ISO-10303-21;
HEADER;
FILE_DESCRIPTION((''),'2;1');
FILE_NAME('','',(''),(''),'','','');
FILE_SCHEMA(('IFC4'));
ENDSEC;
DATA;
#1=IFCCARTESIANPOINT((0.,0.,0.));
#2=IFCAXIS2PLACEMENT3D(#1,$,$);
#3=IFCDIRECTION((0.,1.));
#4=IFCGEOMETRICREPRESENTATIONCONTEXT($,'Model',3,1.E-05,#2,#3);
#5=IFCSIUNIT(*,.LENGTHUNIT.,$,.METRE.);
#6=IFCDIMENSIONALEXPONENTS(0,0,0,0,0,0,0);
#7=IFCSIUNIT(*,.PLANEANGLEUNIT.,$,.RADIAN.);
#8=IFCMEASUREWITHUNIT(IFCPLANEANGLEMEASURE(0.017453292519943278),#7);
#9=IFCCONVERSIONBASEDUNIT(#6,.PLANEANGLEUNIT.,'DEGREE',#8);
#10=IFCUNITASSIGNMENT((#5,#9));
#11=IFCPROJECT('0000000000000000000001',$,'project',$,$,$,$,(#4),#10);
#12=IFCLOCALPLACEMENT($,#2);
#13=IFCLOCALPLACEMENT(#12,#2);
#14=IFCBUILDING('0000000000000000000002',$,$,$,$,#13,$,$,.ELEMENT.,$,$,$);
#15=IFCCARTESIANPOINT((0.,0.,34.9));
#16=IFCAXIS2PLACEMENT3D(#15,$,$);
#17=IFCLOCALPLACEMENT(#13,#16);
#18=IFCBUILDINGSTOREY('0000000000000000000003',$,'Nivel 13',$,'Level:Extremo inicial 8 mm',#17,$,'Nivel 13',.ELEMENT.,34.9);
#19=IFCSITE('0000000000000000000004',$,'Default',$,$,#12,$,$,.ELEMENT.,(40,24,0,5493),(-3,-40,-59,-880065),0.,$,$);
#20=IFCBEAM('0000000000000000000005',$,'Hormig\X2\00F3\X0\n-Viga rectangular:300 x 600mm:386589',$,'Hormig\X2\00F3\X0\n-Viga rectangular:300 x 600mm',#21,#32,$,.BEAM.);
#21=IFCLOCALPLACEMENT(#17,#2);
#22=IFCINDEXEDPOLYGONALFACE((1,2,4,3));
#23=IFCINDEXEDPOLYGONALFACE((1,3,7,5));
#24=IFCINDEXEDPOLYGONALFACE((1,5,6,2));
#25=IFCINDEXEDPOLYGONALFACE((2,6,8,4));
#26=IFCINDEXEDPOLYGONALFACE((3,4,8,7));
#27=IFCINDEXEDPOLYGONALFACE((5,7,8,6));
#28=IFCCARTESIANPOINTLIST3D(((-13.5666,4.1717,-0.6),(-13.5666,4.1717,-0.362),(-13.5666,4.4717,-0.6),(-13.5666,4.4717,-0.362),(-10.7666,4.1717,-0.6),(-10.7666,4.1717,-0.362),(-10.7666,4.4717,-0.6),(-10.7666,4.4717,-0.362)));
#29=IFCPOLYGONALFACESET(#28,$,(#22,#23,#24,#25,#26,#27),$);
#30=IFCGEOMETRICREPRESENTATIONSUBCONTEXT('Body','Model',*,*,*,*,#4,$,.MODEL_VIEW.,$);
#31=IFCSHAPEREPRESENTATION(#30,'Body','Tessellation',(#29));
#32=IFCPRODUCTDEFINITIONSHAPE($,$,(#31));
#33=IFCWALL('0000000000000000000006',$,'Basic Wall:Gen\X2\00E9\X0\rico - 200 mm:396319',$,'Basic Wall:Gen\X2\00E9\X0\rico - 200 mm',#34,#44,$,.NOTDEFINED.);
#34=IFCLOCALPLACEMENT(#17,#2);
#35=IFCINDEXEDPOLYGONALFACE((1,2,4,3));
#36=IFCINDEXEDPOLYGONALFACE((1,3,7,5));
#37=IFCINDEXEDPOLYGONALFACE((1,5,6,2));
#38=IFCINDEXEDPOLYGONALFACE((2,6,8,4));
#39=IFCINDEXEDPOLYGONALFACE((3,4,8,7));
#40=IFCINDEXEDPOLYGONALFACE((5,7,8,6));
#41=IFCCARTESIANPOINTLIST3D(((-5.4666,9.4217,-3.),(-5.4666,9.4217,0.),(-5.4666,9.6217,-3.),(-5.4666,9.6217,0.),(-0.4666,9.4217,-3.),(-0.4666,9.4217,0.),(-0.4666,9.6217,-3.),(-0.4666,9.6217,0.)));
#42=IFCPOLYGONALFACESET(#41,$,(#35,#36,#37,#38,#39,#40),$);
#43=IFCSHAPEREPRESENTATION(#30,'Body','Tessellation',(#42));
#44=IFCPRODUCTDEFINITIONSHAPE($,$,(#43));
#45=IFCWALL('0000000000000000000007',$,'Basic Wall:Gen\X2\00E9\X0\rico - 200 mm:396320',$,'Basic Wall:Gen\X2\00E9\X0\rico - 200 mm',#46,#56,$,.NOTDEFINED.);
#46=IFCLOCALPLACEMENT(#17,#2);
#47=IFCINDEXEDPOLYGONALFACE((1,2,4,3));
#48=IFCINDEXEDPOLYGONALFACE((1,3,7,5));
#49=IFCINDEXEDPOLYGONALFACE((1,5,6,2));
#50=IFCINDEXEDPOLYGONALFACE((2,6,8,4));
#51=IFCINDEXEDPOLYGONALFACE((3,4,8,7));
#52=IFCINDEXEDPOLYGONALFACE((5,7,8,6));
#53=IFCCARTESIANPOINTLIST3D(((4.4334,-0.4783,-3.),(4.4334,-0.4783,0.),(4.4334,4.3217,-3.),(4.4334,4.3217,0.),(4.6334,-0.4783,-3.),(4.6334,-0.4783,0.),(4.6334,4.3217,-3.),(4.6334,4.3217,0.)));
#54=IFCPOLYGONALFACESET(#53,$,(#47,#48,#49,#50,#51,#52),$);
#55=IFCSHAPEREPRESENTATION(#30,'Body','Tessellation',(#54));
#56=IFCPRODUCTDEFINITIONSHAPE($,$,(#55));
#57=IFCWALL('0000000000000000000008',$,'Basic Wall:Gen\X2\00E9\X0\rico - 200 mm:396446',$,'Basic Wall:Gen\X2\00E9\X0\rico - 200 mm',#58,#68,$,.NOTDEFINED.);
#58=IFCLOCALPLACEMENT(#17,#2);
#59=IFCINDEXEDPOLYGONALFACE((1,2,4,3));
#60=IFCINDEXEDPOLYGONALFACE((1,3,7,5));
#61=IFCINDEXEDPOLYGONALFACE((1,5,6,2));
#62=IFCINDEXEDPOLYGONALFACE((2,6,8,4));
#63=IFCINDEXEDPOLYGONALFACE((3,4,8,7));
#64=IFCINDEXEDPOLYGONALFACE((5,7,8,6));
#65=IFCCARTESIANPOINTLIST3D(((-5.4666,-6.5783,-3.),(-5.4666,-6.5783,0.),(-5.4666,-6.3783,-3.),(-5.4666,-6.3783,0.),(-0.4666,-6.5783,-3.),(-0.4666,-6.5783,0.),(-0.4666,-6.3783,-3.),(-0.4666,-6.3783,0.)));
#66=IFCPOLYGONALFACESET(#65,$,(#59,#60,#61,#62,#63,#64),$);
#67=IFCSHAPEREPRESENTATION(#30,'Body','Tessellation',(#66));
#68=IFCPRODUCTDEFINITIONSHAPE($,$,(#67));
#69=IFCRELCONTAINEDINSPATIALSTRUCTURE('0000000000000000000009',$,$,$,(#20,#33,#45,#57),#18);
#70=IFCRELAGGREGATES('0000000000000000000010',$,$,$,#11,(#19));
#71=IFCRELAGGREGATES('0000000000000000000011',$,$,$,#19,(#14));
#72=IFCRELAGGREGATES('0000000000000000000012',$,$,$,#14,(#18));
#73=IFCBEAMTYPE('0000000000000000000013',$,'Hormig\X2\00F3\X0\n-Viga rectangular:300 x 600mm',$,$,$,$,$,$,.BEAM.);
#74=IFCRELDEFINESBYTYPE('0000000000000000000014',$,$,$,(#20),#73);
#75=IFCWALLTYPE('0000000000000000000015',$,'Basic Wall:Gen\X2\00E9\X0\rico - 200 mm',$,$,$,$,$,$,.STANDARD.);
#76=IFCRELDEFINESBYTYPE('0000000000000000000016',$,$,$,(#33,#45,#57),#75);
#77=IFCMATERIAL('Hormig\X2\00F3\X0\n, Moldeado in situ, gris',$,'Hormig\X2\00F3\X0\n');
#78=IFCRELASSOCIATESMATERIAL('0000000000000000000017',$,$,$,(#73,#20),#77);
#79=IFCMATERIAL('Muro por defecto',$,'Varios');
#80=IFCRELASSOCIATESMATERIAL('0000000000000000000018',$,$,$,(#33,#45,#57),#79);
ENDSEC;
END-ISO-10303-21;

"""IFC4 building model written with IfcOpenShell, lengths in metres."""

from ifc_helpers import new_model, entity, si_unit, converted_unit, direction, frame, origin, place, context, subcontext, project, spatial, indexed_curve, outline, extrude, source, transform, mapped, material, type_object, type_shapes, element, save


model = new_model("IFC4")

# Units and contexts
model_context = context("Model", 3, precision=1e-05, world=origin(), true_north=direction((0.0, 1.0)))
body_context = subcontext(model_context, "Body", "Model", "MODEL_VIEW")
ifc_project = project(units=[si_unit("LENGTHUNIT", "METRE"), converted_unit("PLANEANGLEUNIT", "DEGREE", entity("IfcPlaneAngleMeasure", 0.017453292519943278), si_unit("PLANEANGLEUNIT", "RADIAN"), dimensions=[0, 0, 0, 0, 0, 0, 0])], contexts=[model_context])

# Site, building, storey
site_placement = place(None, origin())
site = spatial("IfcSite", under=ifc_project, at=site_placement, Name="Default", CompositionType="ELEMENT", RefLatitude=(40, 24, 0, 5493), RefLongitude=(-3, -40, -59, -880065), RefElevation=0.0)
building_placement = place(site_placement, origin())
building = spatial("IfcBuilding", under=site, at=building_placement, CompositionType="ELEMENT")
storey_placement = place(building_placement, frame((0.0, 0.0, 34.9)))
storey = spatial("IfcBuildingStorey", under=building, at=storey_placement, Name="Nivel 13", ObjectType="Level:Extremo inicial 8 mm", LongName="Nivel 13", CompositionType="ELEMENT", Elevation=34.9)

# Shared definitions
ifc_material_1 = material(Name="Hormigón, Moldeado in situ, gris", Category="Hormigón")

# Beam
beam_type_1 = type_object("IfcBeamType", Name="Hormigón-Viga rectangular:300 x 600mm", PredefinedType="BEAM", material=ifc_material_1)
shared_shape_1 = source(origin(), body_context, "Body", "SweptSolid", [
    extrude(outline(indexed_curve([(-0.119, -0.15), (0.119, -0.15), (0.119, 0.15), (-0.119, 0.15), (-0.119, -0.15)], self_intersect=False)), frame((-10.7666, 4.3217, 34.419), z_axis=(-1.0, 0.0, 0.0), x_axis=(0.0, 0.0, -1.0)), (0.0, 0.0, 1.0), 2.8),
])
type_shapes(beam_type_1, [shared_shape_1])
beam_1_placement = place(storey_placement, frame((0.0, 0.0, -34.9)))
element("IfcBeam", 1, at=beam_1_placement, inside=storey, type_object=beam_type_1, material=ifc_material_1, Name="Hormigón-Viga rectangular:300 x 600mm:386589", ObjectType="Hormigón-Viga rectangular:300 x 600mm", PredefinedType="BEAM", context=body_context, shape_type="MappedRepresentation", body=[
    mapped(shared_shape_1, transform((0.0, 0.0, 0.0), scale=1.0)),
])

# Walls
ifc_material_2 = material(Name="Muro por defecto", Category="Varios")
wall_type = type_object("IfcWallType", Name="Basic Wall:Genérico - 200 mm", PredefinedType="STANDARD")
wall_1_placement = place(storey_placement, frame((-5.4666, 9.5217, -3.0)))
element("IfcWall", 2, at=wall_1_placement, inside=storey, type_object=wall_type, material=ifc_material_2, Name="Basic Wall:Genérico - 200 mm:396319", ObjectType="Basic Wall:Genérico - 200 mm", PredefinedType="NOTDEFINED", context=body_context, shape_type="SweptSolid", body=[
    extrude(outline(indexed_curve([(5.0, 0.1), (0.0, 0.1), (0.0, -0.1), (5.0, -0.1), (5.0, 0.1)], self_intersect=False)), origin(), (0.0, 0.0, 1.0), 3.0),
])
wall_2_placement = place(storey_placement, frame((4.5334, 4.3217, -3.0), z_axis=(0.0, 0.0, 1.0), x_axis=(0.0, -1.0, 0.0)))
element("IfcWall", 3, at=wall_2_placement, inside=storey, type_object=wall_type, material=ifc_material_2, Name="Basic Wall:Genérico - 200 mm:396320", ObjectType="Basic Wall:Genérico - 200 mm", PredefinedType="NOTDEFINED", context=body_context, shape_type="SweptSolid", body=[
    extrude(outline(indexed_curve([(4.8, 0.1), (0.0, 0.1), (0.0, -0.1), (4.8, -0.1), (4.8, 0.1)], self_intersect=False)), origin(), (0.0, 0.0, 1.0), 3.0),
])
wall_3_placement = place(storey_placement, frame((-5.4666, -6.4783, -3.0)))
element("IfcWall", 4, at=wall_3_placement, inside=storey, type_object=wall_type, material=ifc_material_2, Name="Basic Wall:Genérico - 200 mm:396446", ObjectType="Basic Wall:Genérico - 200 mm", PredefinedType="NOTDEFINED", context=body_context, shape_type="SweptSolid", body=[
    extrude(outline(indexed_curve([(5.0, 0.1), (0.0, 0.1), (0.0, -0.1), (5.0, -0.1), (5.0, 0.1)], self_intersect=False)), origin(), (0.0, 0.0, 1.0), 3.0),
])

save(model, "model.ifc")
